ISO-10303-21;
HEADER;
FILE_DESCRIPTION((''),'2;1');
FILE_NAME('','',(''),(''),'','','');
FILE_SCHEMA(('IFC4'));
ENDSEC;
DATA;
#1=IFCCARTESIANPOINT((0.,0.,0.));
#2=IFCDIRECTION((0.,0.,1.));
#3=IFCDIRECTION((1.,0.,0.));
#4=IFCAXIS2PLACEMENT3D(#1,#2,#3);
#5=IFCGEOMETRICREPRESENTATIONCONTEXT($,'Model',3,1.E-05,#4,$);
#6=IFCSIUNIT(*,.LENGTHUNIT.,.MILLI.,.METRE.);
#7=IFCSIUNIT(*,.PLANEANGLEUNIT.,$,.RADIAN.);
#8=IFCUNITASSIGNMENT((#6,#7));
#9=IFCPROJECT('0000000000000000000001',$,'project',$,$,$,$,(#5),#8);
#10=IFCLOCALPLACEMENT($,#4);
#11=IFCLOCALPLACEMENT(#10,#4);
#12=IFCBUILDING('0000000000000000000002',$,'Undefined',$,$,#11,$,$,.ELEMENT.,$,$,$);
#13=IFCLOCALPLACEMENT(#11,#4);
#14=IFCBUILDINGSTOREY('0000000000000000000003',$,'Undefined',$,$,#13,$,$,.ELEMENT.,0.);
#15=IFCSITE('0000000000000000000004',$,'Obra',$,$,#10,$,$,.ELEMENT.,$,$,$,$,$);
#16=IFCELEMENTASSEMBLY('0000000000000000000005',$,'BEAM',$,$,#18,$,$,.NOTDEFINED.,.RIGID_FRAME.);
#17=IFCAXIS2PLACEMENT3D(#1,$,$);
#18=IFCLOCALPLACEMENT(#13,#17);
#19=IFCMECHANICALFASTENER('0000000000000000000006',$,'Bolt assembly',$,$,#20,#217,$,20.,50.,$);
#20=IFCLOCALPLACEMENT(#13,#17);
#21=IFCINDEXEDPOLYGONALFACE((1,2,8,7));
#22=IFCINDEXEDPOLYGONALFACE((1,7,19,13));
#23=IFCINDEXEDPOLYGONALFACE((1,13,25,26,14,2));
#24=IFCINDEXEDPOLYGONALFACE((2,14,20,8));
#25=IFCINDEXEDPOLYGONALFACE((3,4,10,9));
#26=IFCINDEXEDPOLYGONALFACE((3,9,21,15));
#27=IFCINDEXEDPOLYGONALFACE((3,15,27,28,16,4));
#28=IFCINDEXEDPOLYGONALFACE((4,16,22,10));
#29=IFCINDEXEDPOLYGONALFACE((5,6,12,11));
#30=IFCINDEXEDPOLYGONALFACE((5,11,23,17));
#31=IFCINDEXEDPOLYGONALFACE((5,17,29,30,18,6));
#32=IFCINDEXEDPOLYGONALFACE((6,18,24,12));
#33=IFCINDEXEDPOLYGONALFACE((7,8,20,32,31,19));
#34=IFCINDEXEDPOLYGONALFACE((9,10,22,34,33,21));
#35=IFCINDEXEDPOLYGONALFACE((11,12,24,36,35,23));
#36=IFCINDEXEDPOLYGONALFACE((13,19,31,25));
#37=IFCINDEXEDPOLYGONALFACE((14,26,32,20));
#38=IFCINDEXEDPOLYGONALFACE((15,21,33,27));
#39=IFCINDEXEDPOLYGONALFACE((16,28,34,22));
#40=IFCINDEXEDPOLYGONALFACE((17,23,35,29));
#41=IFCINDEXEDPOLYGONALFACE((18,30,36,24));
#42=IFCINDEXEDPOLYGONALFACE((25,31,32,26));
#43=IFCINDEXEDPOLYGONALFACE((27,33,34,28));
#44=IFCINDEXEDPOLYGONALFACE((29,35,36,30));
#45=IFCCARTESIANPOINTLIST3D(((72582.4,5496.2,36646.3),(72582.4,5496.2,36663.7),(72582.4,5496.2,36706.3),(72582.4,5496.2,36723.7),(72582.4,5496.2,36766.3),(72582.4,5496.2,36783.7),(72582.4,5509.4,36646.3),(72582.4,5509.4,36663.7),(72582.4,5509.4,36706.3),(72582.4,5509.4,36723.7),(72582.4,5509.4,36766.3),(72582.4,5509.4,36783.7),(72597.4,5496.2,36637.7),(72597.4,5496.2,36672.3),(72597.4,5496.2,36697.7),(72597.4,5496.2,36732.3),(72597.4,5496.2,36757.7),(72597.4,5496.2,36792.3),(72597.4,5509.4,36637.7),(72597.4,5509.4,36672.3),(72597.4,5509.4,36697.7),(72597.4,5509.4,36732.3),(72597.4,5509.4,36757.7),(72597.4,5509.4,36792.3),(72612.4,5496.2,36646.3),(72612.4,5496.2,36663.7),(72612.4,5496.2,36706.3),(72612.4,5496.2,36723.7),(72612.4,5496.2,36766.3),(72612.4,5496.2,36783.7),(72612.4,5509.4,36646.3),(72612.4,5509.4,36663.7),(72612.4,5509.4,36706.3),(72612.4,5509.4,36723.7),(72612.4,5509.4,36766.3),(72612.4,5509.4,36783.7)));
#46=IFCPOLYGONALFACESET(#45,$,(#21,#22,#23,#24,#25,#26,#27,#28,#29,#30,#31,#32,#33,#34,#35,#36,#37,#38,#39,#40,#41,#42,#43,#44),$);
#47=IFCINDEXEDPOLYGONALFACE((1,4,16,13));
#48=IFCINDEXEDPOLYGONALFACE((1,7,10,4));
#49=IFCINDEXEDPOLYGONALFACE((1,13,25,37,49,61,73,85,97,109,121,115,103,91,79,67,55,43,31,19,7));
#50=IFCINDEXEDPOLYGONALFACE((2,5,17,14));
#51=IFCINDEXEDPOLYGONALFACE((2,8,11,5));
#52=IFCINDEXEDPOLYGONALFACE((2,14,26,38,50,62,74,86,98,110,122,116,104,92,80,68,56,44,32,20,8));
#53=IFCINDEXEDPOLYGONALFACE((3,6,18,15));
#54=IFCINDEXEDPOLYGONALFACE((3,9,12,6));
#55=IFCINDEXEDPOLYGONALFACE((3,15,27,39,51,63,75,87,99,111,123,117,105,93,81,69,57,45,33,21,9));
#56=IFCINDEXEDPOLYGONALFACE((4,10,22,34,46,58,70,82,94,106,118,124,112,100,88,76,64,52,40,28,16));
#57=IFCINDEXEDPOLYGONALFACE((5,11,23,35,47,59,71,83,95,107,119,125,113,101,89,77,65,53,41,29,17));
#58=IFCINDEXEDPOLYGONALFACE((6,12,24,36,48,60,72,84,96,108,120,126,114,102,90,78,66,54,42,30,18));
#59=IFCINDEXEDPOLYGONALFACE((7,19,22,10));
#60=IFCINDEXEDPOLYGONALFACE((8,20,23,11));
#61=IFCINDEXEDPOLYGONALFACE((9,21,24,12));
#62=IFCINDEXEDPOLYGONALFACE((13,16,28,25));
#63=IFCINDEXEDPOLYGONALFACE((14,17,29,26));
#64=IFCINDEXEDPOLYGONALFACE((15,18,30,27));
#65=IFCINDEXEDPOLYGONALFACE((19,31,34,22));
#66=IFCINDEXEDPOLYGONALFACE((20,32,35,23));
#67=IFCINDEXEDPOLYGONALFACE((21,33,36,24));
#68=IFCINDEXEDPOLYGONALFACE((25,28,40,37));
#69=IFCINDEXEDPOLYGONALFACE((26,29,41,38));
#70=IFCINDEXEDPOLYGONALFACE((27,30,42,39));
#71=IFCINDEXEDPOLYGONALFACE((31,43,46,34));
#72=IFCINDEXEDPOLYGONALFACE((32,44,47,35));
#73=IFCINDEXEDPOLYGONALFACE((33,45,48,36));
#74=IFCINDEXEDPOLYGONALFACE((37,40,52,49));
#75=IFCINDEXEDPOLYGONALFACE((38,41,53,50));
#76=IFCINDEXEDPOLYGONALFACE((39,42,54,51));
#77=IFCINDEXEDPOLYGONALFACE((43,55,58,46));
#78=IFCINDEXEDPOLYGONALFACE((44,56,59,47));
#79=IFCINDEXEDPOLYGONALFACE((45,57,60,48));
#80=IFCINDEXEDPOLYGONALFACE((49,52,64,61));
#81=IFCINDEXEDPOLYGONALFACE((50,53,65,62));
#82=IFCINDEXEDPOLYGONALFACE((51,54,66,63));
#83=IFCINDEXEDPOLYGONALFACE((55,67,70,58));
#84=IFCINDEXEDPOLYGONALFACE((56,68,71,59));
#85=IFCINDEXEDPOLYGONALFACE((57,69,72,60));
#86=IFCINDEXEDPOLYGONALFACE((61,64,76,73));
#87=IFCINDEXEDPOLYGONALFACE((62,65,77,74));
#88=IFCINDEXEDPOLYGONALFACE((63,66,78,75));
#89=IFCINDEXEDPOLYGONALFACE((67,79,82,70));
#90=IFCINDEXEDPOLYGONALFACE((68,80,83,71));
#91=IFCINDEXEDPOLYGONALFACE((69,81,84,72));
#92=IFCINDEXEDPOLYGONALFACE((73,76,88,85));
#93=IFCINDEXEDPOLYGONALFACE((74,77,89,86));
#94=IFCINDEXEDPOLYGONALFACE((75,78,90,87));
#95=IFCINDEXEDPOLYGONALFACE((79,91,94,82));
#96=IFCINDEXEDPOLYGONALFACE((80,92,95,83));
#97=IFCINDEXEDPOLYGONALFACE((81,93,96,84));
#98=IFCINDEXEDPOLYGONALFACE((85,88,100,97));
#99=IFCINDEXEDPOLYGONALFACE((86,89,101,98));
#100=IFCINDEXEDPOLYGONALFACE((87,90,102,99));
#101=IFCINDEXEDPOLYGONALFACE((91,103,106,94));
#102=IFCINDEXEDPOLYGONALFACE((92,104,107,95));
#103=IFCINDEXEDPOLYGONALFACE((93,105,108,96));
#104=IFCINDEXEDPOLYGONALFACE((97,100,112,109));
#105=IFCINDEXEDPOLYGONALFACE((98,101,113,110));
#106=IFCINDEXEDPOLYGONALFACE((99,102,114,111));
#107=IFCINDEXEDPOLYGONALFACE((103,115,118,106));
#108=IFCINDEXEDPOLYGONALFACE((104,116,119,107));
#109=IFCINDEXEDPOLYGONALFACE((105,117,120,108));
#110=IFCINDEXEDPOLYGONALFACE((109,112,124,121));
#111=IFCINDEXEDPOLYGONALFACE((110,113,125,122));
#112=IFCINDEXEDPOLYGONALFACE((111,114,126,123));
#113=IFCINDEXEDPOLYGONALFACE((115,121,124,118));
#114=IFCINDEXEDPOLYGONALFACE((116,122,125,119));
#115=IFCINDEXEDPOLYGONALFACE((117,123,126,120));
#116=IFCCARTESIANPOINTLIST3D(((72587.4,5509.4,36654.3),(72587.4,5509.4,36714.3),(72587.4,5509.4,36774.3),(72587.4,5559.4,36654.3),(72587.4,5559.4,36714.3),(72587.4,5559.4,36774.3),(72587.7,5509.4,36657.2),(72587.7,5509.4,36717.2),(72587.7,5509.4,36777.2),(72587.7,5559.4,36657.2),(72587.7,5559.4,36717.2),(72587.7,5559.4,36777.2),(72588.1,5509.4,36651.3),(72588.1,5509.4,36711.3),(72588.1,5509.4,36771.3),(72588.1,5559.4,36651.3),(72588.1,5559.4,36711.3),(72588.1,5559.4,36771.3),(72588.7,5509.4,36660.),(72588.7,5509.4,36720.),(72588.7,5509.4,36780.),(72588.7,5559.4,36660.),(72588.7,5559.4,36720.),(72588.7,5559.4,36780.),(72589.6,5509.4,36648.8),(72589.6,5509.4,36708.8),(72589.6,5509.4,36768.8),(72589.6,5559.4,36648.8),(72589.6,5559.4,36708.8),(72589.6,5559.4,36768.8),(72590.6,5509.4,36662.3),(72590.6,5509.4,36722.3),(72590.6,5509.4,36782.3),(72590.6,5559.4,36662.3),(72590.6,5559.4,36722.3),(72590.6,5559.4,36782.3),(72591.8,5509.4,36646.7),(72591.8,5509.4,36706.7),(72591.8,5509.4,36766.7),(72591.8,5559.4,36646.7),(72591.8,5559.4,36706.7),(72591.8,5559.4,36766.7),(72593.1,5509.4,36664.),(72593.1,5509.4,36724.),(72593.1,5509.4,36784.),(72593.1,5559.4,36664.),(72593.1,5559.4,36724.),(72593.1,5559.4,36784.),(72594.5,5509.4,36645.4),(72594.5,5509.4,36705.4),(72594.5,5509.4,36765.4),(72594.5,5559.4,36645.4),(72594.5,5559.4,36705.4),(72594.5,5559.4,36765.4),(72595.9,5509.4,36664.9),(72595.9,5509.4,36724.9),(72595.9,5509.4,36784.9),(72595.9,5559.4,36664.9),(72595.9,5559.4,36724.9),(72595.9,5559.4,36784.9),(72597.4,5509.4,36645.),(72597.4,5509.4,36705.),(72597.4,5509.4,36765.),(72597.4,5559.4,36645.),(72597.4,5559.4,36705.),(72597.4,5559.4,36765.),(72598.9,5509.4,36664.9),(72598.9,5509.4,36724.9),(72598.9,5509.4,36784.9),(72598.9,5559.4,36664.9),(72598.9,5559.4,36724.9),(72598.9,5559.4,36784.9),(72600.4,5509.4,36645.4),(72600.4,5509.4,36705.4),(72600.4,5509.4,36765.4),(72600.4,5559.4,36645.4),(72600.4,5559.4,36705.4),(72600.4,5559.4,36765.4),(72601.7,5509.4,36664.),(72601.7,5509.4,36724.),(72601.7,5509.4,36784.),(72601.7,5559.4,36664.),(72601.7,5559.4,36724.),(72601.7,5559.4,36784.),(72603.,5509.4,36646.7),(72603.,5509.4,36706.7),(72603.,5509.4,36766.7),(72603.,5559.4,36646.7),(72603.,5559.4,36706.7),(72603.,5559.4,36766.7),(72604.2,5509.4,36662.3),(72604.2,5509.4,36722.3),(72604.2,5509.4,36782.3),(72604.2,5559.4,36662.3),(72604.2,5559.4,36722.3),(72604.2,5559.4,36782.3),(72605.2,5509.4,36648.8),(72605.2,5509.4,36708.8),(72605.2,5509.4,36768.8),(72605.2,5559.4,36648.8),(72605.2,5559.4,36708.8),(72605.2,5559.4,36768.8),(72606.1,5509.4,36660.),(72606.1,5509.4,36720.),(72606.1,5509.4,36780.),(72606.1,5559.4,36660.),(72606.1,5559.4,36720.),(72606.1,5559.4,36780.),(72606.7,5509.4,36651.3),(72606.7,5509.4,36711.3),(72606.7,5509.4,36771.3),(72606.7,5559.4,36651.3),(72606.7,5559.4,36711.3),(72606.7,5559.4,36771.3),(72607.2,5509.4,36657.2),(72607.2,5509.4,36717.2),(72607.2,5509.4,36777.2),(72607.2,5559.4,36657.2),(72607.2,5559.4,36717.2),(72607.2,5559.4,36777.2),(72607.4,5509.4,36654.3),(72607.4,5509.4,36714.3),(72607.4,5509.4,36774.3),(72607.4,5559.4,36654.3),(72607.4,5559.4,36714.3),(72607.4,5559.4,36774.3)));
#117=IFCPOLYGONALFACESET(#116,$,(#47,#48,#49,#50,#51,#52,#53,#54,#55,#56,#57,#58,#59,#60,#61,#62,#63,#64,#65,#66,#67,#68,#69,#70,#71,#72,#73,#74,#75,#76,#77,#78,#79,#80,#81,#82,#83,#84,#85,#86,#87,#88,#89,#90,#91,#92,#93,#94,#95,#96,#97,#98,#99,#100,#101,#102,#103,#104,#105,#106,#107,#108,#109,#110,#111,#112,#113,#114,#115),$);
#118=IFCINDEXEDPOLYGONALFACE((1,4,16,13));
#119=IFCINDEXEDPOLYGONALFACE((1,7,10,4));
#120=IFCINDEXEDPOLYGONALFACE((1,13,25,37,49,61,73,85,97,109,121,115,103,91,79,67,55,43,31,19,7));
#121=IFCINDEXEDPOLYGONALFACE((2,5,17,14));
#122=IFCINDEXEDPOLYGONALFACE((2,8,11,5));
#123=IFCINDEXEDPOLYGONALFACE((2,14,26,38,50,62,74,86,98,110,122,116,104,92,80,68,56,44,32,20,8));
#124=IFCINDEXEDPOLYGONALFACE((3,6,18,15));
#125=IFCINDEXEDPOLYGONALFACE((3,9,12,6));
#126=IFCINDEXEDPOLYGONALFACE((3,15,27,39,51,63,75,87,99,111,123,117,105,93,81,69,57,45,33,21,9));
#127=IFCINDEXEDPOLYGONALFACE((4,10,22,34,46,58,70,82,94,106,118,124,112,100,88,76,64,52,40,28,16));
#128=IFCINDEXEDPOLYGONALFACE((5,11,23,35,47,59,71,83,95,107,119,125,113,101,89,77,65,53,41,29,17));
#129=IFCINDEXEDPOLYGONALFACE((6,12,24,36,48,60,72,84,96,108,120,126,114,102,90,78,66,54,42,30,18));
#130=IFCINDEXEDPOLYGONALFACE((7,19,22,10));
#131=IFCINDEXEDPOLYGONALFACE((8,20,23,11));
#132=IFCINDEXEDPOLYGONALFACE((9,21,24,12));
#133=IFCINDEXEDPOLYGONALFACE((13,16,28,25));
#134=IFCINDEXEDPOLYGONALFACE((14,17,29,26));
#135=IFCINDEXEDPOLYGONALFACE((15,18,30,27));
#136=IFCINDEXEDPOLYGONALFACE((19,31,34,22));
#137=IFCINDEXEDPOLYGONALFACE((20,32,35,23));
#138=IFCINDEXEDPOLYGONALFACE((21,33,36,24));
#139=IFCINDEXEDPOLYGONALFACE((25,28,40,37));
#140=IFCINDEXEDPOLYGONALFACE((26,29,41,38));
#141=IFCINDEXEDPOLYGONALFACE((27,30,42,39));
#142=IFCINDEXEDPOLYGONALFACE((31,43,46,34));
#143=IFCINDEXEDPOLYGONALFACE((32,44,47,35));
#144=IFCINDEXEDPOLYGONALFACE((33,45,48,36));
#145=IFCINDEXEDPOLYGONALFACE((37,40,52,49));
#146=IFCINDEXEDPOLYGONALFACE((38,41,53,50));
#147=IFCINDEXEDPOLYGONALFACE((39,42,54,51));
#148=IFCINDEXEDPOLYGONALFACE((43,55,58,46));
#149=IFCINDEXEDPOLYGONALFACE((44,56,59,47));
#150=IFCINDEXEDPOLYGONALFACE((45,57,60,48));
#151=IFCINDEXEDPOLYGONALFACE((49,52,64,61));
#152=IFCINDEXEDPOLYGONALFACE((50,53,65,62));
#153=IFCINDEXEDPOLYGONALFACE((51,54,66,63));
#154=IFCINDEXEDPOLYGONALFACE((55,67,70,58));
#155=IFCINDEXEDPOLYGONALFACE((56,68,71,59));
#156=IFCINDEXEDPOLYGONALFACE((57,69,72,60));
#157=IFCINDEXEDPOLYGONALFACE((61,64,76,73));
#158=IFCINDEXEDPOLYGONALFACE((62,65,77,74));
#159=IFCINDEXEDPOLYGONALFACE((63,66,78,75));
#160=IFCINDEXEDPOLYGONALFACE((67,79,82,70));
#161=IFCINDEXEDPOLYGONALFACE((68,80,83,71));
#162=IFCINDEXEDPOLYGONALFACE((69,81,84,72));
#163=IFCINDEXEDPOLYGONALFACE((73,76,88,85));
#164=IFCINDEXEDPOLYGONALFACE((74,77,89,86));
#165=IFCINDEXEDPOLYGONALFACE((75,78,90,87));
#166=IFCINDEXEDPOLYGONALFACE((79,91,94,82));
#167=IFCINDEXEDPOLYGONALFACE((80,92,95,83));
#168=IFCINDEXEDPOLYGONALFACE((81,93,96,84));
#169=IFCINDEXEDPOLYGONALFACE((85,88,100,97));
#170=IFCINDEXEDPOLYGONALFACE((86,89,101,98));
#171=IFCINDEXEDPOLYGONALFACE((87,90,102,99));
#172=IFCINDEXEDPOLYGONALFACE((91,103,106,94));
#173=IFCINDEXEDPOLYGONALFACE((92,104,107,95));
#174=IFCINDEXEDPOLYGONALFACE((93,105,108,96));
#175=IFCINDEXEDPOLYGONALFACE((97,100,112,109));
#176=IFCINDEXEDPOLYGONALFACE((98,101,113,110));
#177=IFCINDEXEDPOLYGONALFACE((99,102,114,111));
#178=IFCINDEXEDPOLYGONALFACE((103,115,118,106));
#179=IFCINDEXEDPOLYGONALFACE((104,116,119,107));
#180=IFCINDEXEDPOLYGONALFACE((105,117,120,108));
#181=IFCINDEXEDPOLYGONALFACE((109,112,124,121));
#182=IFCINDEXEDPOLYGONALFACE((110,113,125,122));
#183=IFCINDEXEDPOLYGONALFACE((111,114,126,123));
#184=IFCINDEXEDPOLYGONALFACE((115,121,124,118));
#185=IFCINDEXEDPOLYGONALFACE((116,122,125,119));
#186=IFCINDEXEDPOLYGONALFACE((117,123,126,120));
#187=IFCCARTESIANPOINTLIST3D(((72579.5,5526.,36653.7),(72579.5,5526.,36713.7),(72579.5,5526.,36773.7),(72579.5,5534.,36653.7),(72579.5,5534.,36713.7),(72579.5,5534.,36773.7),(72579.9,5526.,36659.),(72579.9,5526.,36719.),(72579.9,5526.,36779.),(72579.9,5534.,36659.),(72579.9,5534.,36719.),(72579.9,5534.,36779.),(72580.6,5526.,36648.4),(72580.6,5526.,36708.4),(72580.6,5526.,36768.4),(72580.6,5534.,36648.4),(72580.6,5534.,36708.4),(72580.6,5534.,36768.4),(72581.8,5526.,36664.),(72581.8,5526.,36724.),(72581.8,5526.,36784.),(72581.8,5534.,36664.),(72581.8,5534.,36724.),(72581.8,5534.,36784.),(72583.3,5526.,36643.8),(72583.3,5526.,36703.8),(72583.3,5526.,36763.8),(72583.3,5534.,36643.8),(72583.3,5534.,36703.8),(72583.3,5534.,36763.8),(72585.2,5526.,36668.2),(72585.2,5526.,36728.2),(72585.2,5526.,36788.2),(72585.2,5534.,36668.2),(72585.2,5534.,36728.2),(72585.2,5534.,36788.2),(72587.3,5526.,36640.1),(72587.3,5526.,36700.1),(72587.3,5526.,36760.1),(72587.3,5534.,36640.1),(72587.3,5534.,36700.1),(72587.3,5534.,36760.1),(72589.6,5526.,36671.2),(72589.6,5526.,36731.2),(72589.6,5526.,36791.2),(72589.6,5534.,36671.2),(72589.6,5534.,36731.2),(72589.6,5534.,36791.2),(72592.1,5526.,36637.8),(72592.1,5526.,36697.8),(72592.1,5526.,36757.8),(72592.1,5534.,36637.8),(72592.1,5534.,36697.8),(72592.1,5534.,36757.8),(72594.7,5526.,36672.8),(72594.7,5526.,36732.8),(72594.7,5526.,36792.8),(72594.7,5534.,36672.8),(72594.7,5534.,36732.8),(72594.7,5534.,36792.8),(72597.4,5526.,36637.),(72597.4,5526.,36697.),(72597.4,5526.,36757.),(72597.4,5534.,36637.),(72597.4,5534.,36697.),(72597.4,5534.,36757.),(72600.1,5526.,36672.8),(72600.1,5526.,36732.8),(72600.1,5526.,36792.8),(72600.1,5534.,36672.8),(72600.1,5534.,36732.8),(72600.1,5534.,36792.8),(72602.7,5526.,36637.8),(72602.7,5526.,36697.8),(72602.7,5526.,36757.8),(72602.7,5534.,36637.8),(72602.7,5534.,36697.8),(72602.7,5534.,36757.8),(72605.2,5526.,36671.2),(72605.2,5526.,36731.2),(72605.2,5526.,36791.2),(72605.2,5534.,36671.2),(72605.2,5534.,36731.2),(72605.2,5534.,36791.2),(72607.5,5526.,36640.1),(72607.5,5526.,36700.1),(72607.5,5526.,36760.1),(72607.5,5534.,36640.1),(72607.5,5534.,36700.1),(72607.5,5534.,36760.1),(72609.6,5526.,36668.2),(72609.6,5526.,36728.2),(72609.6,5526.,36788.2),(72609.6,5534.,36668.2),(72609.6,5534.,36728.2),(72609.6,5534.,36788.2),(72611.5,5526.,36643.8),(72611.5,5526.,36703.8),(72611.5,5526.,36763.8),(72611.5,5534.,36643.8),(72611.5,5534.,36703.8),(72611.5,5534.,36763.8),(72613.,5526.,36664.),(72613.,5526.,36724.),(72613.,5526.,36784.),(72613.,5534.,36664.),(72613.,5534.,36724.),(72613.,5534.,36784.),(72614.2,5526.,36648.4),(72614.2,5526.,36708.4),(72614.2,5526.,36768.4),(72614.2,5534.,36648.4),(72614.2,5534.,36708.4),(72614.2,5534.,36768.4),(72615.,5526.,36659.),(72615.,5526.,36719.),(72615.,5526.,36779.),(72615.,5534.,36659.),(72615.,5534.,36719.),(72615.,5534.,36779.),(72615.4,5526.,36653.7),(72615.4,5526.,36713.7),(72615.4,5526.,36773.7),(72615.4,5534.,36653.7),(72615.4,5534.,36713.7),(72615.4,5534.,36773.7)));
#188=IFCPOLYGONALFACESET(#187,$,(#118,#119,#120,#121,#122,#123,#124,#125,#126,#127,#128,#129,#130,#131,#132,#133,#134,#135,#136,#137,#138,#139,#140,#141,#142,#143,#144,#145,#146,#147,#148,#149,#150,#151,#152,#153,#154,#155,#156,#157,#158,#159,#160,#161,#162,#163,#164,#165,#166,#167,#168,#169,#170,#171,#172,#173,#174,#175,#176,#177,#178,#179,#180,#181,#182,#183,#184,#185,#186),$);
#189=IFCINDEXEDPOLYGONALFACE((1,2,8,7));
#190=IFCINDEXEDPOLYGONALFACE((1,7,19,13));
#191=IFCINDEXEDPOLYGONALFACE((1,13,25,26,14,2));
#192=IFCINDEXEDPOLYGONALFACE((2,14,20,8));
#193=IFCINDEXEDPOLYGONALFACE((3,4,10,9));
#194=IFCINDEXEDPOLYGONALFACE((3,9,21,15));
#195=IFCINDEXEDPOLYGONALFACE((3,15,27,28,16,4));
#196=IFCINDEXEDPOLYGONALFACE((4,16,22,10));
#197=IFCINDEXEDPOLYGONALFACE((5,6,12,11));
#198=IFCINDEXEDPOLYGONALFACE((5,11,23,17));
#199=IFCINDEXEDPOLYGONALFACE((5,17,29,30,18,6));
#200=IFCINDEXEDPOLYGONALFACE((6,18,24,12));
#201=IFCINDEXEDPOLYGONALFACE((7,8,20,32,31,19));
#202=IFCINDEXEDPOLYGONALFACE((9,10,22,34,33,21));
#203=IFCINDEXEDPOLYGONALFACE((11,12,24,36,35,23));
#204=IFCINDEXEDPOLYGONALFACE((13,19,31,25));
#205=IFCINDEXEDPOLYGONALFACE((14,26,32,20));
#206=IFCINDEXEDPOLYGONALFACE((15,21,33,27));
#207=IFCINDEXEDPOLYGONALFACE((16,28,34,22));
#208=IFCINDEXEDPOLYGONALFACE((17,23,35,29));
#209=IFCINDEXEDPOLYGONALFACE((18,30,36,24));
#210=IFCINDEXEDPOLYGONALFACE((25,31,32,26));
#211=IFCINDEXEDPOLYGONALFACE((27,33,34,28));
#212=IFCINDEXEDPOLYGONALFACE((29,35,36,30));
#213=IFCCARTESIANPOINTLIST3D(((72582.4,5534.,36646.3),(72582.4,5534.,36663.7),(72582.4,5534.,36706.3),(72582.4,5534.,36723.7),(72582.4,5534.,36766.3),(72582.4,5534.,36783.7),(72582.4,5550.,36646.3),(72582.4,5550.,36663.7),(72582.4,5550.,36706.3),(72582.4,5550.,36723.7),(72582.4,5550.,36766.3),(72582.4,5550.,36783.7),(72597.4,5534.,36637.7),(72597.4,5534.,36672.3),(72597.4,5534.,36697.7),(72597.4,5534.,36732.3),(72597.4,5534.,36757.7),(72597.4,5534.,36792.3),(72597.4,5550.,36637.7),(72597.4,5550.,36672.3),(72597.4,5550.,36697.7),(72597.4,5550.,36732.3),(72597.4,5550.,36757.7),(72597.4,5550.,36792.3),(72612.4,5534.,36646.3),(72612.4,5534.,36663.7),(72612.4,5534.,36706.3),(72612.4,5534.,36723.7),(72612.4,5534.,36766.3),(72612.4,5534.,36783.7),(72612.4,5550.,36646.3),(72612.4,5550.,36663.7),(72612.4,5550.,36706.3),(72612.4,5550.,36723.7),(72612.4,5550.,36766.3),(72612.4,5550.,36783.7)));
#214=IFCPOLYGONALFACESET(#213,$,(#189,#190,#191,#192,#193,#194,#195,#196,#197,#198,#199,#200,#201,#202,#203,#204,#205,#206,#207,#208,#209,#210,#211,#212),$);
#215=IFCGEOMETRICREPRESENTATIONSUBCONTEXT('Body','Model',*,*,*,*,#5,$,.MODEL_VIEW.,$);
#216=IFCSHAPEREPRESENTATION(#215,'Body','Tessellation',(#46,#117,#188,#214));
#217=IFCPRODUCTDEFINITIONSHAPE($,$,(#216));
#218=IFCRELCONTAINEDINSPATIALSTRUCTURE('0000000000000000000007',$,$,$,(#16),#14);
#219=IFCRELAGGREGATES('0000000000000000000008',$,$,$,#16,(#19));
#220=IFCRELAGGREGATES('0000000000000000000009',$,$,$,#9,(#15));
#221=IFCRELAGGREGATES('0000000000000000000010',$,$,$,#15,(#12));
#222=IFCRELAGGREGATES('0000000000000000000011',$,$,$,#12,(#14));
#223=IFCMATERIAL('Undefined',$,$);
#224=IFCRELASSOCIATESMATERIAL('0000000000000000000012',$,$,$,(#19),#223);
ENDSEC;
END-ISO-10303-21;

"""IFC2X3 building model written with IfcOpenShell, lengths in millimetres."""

from ifc_helpers import new_model, si_unit, frame, origin_with_axes, origin_2d_with_axis, place, context, subcontext, project, spatial, polyline, circle, outline, extrude, source, transform, mapped, material, element, aggregate, save


model = new_model("IFC2X3")

# Units and contexts
model_context = context("Model", 3, precision=1e-05, world=origin_with_axes())
body_context = subcontext(model_context, "Body", "Model", "MODEL_VIEW")
ifc_project = project(units=[si_unit("LENGTHUNIT", "METRE", prefix="MILLI"), si_unit("PLANEANGLEUNIT", "RADIAN")], contexts=[model_context])

# Site, building, storey
site_placement = place(None, origin_with_axes())
site = spatial("IfcSite", under=ifc_project, at=site_placement, Name="Obra", CompositionType="ELEMENT")
building_placement = place(site_placement, origin_with_axes())
building = spatial("IfcBuilding", under=site, at=building_placement, Name="Undefined", CompositionType="ELEMENT")
storey_placement = place(building_placement, origin_with_axes())
storey = spatial("IfcBuildingStorey", under=building, at=storey_placement, Name="Undefined", CompositionType="ELEMENT", Elevation=0.0)

# Element assembly
assembly_1_placement = place(storey_placement, origin_with_axes())
assembly_1 = element("IfcElementAssembly", 1, at=assembly_1_placement, inside=storey, Name="BEAM", AssemblyPlace="NOTDEFINED", PredefinedType="RIGID_FRAME")

# Shared definitions
ifc_material_1 = material(Name="Undefined")

# Mechanical fastener
shared_shape_1 = source(origin_with_axes(), body_context, "Body", "SweptSolid", [
    extrude(outline(polyline([(17.3, 0.0), (8.7, 15.0), (-8.7, 15.0), (-17.3, 0.0), (-8.7, -15.0), (8.7, -15.0), (17.3, 0.0)])), frame((0.0, -26.5, 0.0), z_axis=(0.0, 1.0, 0.0), x_axis=(1.0, 0.0, 0.0)), (0.0, 0.0, 1.0), 13.2),
    extrude(circle(Radius=10.0, at=origin_2d_with_axis()), frame((0.0, -13.3, 0.0), z_axis=(0.0, 1.0, 0.0), x_axis=(1.0, 0.0, 0.0)), (0.0, 0.0, 1.0), 50.0),
    extrude(circle(Radius=18.0, at=origin_2d_with_axis()), frame((0.0, 3.3, 0.0), z_axis=(0.0, 1.0, 0.0), x_axis=(1.0, 0.0, 0.0)), (0.0, 0.0, 1.0), 8.0),
    extrude(outline(polyline([(17.3, 0.0), (8.7, 15.0), (-8.7, 15.0), (-17.3, 0.0), (-8.7, -15.0), (8.7, -15.0), (17.3, 0.0)])), frame((0.0, 11.3, 0.0), z_axis=(0.0, 1.0, 0.0), x_axis=(1.0, 0.0, 0.0)), (0.0, 0.0, 1.0), 16.0),
])
mechanical_fastener_1_placement = place(assembly_1_placement, frame((72547.4, 5522.7, 36815.0), z_axis=(1.0, 0.000002, 0.0), x_axis=(0.0, 0.0, -1.0)))
mechanical_fastener_1 = element("IfcMechanicalFastener", 2, at=mechanical_fastener_1_placement, material=ifc_material_1, Name="Bolt assembly", NominalDiameter=20.0, NominalLength=50.0, context=body_context, shape_type="MappedRepresentation", body=[
    mapped(shared_shape_1, transform((40.0, 0.0, 50.0))),
    mapped(shared_shape_1, transform((100.0, 0.0, 50.0))),
    mapped(shared_shape_1, transform((160.0, 0.0, 50.0))),
])

aggregate(assembly_1, [mechanical_fastener_1])

save(model, "model.ifc")
